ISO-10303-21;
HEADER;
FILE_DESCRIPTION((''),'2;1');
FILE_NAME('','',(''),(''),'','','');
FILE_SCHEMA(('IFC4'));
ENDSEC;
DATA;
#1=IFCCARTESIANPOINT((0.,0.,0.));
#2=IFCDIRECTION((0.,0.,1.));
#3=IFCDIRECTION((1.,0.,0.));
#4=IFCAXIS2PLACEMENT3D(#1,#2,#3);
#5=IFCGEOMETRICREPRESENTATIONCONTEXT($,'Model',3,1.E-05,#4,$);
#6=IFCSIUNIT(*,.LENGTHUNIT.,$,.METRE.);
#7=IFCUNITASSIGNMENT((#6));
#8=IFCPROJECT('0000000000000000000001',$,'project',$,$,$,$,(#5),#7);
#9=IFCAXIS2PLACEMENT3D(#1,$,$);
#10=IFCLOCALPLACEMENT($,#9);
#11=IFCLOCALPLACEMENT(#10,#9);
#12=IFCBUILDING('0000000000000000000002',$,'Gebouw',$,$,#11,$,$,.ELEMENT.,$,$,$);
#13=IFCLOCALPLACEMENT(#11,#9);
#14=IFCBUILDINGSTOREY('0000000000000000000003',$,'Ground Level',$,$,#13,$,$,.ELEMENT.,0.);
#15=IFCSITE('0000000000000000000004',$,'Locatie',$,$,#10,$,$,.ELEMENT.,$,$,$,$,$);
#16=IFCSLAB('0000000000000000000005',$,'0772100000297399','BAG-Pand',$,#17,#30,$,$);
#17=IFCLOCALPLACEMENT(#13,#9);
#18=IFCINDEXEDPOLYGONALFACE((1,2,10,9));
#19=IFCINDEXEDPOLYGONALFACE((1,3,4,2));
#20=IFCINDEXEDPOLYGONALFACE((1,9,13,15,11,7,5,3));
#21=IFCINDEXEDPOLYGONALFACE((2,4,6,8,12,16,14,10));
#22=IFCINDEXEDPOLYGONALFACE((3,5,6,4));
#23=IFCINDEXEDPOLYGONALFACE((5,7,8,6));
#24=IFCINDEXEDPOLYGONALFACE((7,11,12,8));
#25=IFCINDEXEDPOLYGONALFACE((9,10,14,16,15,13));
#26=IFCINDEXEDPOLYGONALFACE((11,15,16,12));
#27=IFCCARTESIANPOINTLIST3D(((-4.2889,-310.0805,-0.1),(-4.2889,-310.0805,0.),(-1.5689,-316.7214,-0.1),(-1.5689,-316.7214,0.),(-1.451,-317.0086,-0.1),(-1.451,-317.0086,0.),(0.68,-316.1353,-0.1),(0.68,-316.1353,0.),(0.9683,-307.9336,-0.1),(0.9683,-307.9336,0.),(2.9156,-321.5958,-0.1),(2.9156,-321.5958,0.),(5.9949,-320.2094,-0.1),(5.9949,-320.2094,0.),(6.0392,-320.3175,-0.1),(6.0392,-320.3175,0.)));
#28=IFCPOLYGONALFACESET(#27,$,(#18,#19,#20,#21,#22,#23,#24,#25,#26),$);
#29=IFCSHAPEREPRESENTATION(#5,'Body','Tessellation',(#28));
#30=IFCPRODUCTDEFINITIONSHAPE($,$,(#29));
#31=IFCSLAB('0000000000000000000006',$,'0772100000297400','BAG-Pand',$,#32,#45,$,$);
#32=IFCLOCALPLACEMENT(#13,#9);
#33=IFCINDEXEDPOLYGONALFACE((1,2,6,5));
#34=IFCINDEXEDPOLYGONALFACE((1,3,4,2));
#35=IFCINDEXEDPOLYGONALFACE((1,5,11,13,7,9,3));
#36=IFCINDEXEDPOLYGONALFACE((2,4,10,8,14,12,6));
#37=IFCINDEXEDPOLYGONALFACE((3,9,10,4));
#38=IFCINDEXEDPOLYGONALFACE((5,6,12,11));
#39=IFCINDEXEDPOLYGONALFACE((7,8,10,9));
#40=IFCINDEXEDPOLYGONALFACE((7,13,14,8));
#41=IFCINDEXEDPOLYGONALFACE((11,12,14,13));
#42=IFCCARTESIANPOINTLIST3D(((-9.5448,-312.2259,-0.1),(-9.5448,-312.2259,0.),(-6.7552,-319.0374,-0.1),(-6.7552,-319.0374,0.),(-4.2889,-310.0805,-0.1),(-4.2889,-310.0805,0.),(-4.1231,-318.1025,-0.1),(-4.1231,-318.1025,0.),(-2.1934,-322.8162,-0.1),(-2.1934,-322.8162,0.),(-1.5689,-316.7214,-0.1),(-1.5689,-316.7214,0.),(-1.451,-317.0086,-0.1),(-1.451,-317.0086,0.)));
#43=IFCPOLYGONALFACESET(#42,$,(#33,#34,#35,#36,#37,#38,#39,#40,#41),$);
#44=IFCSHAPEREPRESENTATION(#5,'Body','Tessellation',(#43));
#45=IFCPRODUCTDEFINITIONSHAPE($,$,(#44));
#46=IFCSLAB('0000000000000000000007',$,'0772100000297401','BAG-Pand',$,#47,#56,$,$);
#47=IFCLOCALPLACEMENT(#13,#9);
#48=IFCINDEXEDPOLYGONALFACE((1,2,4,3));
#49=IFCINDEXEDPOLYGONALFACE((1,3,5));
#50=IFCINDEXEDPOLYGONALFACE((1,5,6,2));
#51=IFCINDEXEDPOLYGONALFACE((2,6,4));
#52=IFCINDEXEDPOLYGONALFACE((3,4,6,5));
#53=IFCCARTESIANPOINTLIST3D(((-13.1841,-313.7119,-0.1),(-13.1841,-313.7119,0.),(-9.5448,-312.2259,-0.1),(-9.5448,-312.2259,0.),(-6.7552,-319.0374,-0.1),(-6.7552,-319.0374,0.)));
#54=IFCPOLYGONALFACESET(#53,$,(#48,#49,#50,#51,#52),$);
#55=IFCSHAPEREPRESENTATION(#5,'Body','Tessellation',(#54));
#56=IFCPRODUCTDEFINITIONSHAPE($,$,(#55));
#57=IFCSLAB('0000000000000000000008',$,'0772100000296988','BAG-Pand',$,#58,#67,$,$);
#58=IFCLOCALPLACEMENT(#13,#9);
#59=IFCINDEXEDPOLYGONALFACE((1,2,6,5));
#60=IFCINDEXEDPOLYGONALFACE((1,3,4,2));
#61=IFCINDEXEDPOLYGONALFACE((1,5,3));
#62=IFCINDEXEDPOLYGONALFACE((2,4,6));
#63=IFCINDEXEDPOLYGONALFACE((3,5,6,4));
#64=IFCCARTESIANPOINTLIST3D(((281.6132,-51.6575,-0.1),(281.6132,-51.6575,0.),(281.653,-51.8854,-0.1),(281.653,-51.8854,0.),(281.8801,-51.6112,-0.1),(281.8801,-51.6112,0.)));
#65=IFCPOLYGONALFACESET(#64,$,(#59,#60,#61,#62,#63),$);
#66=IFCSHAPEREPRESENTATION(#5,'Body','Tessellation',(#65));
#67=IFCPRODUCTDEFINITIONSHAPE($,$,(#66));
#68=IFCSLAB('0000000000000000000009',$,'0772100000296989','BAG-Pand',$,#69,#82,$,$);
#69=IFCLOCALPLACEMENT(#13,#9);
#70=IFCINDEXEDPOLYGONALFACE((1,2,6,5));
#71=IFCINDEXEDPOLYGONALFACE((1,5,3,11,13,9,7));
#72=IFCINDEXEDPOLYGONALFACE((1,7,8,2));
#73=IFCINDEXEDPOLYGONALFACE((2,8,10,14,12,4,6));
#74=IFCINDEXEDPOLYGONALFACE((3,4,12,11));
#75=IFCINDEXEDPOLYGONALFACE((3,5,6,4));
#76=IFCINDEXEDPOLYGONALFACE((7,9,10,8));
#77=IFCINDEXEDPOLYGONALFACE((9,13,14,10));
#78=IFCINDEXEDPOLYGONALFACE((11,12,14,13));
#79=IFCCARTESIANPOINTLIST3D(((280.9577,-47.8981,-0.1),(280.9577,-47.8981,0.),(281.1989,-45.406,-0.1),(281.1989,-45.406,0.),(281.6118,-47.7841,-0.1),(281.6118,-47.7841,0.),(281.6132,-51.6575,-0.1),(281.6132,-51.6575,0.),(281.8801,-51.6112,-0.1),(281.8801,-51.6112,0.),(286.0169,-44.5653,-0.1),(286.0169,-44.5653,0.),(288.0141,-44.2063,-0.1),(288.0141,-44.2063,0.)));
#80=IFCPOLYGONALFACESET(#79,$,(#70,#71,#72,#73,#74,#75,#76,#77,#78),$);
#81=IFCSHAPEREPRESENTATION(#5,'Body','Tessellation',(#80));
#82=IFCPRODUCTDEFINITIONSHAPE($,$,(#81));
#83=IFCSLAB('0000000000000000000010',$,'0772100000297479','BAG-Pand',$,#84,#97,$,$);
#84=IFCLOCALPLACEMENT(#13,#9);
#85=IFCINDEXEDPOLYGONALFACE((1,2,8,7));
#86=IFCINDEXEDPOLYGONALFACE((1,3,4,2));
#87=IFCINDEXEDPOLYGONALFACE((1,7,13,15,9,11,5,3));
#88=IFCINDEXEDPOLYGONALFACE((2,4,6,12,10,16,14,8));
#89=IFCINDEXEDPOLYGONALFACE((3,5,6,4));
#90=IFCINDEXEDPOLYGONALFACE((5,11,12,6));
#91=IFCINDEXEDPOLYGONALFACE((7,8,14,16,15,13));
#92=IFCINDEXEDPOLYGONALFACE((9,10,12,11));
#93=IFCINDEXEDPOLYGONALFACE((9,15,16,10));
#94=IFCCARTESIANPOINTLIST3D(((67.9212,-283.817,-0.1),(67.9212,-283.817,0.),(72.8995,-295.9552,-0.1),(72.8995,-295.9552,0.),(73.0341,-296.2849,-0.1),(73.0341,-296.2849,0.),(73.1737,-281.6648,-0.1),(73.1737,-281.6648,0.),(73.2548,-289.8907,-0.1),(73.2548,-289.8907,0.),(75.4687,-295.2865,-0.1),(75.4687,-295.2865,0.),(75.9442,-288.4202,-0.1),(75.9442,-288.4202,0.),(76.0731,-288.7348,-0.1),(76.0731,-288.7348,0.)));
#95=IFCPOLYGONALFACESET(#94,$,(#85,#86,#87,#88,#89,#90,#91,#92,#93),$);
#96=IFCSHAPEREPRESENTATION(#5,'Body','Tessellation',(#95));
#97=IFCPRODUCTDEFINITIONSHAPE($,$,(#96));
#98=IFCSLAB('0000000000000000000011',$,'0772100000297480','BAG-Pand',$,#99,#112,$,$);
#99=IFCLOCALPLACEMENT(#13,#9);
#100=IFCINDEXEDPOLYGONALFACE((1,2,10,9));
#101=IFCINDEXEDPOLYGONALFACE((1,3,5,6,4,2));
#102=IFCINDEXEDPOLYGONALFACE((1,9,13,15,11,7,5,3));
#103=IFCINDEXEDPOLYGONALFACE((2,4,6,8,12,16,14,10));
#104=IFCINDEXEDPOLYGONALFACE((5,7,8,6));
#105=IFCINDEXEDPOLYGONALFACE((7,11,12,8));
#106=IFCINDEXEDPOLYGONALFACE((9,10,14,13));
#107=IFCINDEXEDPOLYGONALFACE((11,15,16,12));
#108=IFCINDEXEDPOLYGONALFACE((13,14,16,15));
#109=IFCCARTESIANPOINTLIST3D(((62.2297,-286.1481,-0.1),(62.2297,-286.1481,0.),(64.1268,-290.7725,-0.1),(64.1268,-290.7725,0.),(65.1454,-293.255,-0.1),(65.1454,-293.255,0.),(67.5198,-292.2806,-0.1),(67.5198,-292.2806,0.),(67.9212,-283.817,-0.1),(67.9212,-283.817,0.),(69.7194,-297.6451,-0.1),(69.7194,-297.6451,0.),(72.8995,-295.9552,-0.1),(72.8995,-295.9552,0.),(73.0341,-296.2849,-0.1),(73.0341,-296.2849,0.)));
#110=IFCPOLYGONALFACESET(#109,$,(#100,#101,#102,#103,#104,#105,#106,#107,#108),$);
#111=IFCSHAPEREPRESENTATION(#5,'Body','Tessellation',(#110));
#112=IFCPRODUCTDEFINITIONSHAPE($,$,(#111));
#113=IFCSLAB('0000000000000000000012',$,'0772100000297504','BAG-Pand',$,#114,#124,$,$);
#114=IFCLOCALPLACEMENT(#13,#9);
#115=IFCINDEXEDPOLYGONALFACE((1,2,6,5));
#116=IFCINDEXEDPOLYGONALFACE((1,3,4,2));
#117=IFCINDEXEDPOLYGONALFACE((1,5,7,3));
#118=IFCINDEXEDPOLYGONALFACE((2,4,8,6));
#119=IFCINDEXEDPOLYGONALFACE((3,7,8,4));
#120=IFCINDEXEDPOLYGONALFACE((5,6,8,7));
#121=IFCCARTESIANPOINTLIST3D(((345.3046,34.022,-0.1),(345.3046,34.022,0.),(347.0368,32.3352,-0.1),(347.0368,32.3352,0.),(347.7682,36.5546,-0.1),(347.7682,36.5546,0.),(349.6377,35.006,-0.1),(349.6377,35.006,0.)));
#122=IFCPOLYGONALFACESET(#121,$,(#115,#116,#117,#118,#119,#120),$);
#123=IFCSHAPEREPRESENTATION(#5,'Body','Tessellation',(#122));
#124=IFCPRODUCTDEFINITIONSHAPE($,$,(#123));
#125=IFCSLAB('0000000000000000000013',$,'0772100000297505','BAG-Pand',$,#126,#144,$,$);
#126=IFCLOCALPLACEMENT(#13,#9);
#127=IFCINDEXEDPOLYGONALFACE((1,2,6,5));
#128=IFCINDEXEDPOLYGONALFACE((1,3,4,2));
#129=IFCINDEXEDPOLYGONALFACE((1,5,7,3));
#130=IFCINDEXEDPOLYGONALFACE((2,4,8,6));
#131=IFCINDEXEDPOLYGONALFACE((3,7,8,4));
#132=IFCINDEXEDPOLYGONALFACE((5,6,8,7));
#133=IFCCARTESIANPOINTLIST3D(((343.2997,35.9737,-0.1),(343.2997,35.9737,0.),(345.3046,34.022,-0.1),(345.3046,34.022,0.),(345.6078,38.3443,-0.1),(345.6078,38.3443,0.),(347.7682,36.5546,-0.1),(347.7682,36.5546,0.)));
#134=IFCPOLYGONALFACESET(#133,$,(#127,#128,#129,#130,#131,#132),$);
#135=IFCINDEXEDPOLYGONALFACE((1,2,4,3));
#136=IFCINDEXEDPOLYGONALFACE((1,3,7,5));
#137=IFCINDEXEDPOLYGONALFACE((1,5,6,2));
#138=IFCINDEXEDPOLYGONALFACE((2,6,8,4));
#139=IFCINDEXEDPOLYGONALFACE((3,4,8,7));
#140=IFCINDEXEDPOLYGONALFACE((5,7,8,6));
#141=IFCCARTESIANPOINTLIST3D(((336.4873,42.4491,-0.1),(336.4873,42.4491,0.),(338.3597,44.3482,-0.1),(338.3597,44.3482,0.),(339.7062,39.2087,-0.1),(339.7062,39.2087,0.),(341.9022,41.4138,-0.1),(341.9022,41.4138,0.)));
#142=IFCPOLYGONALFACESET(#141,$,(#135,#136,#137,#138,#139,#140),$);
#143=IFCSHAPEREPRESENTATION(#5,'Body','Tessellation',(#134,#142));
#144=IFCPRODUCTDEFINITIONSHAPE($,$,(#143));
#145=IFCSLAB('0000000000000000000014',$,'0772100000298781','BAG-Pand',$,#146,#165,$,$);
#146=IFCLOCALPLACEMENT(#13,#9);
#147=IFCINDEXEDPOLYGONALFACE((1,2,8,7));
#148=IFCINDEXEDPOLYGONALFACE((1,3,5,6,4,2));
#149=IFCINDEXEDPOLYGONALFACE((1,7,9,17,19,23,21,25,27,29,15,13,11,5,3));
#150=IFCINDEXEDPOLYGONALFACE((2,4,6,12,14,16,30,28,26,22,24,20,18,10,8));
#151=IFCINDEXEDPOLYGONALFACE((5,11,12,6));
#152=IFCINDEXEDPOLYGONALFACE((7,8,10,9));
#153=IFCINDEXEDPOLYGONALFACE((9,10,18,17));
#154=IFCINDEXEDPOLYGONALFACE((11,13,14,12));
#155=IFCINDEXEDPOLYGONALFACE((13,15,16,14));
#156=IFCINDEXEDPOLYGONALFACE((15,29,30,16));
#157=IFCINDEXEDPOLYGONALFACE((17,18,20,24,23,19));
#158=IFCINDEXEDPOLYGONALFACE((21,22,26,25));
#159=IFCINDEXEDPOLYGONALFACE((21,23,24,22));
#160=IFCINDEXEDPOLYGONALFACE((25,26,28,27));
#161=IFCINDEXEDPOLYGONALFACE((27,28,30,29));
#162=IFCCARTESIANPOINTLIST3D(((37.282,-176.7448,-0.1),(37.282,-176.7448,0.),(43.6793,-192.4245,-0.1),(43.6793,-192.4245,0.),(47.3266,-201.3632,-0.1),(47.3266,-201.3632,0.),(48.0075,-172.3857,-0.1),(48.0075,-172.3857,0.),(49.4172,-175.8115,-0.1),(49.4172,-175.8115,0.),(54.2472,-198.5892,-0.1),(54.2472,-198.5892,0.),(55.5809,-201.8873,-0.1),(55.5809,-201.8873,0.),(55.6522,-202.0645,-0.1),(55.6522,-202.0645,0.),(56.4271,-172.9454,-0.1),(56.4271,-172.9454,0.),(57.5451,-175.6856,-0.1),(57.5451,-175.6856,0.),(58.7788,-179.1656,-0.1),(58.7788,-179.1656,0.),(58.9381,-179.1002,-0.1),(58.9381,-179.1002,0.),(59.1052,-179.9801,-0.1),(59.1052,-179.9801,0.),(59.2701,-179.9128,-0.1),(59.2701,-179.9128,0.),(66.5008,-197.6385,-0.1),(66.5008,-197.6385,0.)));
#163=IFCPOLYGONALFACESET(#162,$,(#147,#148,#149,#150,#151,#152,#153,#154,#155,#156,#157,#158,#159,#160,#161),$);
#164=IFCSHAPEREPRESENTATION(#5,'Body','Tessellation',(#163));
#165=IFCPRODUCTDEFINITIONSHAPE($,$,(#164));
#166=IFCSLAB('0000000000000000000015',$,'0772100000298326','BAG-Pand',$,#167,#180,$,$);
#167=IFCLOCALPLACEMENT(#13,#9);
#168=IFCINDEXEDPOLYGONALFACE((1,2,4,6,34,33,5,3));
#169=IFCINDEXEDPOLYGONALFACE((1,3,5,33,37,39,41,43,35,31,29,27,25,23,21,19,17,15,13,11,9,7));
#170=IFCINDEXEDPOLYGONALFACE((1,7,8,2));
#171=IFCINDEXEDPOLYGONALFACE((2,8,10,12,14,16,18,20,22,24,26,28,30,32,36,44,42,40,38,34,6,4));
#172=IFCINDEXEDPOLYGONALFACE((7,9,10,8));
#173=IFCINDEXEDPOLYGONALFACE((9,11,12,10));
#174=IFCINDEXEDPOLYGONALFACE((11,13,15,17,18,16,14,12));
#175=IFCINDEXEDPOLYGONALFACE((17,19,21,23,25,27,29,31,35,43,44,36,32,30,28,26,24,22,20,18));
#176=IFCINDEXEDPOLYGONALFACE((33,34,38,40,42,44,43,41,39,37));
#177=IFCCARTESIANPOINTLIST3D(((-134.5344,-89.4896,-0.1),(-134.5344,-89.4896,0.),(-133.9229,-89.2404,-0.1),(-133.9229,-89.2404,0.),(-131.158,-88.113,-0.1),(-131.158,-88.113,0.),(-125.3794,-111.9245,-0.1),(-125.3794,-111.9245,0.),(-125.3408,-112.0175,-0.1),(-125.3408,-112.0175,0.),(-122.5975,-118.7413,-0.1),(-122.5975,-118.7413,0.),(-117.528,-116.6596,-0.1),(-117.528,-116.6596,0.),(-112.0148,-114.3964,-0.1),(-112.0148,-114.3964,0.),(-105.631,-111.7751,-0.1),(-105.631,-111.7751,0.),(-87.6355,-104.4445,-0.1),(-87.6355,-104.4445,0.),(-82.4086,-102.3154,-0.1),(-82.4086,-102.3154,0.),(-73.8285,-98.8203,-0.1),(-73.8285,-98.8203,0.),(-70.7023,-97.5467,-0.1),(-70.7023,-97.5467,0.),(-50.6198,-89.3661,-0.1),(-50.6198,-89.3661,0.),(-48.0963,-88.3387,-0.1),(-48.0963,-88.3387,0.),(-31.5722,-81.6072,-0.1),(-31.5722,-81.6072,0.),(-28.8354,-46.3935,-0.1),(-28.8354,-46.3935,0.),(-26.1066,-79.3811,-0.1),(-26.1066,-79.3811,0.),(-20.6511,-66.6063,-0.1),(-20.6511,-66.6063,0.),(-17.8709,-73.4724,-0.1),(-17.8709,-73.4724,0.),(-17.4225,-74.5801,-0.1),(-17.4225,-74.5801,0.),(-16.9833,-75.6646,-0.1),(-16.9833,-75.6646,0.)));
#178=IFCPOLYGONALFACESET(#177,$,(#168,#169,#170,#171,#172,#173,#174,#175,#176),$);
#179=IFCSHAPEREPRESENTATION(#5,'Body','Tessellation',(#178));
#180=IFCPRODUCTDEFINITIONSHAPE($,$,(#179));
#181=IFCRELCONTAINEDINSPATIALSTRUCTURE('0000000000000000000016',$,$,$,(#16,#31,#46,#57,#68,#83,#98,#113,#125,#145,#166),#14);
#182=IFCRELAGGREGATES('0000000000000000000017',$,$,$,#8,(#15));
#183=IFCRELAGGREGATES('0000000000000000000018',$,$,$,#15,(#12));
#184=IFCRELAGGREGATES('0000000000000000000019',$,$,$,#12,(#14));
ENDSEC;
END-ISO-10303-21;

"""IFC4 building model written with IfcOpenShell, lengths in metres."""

from ifc_helpers import new_model, si_unit, frame, origin, origin_with_axes, place, context, project, spatial, polyline, outline, extrude, element, save


model = new_model("IFC4")

# Units and contexts
model_context = context("Model", 3, precision=1e-05, world=origin_with_axes())
ifc_project = project(units=[si_unit("LENGTHUNIT", "METRE")], contexts=[model_context])

# Site, building, storey
site_placement = place(None, origin())
site = spatial("IfcSite", under=ifc_project, at=site_placement, Name="Locatie", CompositionType="ELEMENT")
building_placement = place(site_placement, origin())
building = spatial("IfcBuilding", under=site, at=building_placement, Name="Gebouw", CompositionType="ELEMENT")
storey_placement = place(building_placement, origin())
storey = spatial("IfcBuildingStorey", under=building, at=storey_placement, Name="Ground Level", CompositionType="ELEMENT", Elevation=0.0)

# Slabs
slab_1_placement = place(storey_placement, origin())
element("IfcSlab", 1, at=slab_1_placement, inside=storey, Name="0772100000297399", Description="BAG-Pand", context=model_context, shape_type="SweptSolid", body=[
    extrude(outline(polyline([(0.9683, -307.9336), (5.9949, -320.2094), (6.0392, -320.3175), (2.9156, -321.5958), (0.68, -316.1353), (-1.451, -317.0086), (-1.5689, -316.7214), (-4.2889, -310.0805), (0.9683, -307.9336)])), frame((0.0, 0.0, -0.1), z_axis=(0.0, 0.0, 1.0), x_axis=(1.0, 0.0, 0.0)), (0.0, 0.0, 1.0), 0.1),
])
slab_2_placement = place(storey_placement, origin())
element("IfcSlab", 2, at=slab_2_placement, inside=storey, Name="0772100000297400", Description="BAG-Pand", context=model_context, shape_type="SweptSolid", body=[
    extrude(outline(polyline([(-9.5448, -312.2259), (-4.2889, -310.0805), (-1.5689, -316.7214), (-1.451, -317.0086), (-4.1231, -318.1025), (-2.1934, -322.8162), (-6.7552, -319.0374), (-9.5448, -312.2259)])), frame((0.0, 0.0, -0.1), z_axis=(0.0, 0.0, 1.0), x_axis=(1.0, 0.0, 0.0)), (0.0, 0.0, 1.0), 0.1),
])
slab_3_placement = place(storey_placement, origin())
element("IfcSlab", 3, at=slab_3_placement, inside=storey, Name="0772100000297401", Description="BAG-Pand", context=model_context, shape_type="SweptSolid", body=[
    extrude(outline(polyline([(-9.5448, -312.2259), (-6.7552, -319.0374), (-13.1841, -313.7119), (-9.5448, -312.2259)])), frame((0.0, 0.0, -0.1), z_axis=(0.0, 0.0, 1.0), x_axis=(1.0, 0.0, 0.0)), (0.0, 0.0, 1.0), 0.1),
])
slab_4_placement = place(storey_placement, origin())
element("IfcSlab", 4, at=slab_4_placement, inside=storey, Name="0772100000296988", Description="BAG-Pand", context=model_context, shape_type="SweptSolid", body=[
    extrude(outline(polyline([(281.6132, -51.6575), (281.8801, -51.6112), (281.653, -51.8854), (281.6132, -51.6575)])), frame((0.0, 0.0, -0.1), z_axis=(0.0, 0.0, 1.0), x_axis=(1.0, 0.0, 0.0)), (0.0, 0.0, 1.0), 0.1),
])
slab_5_placement = place(storey_placement, origin())
element("IfcSlab", 5, at=slab_5_placement, inside=storey, Name="0772100000296989", Description="BAG-Pand", context=model_context, shape_type="SweptSolid", body=[
    extrude(outline(polyline([(281.6132, -51.6575), (280.9577, -47.8981), (281.6118, -47.7841), (281.1989, -45.406), (286.0169, -44.5653), (288.0141, -44.2063), (281.8801, -51.6112), (281.6132, -51.6575)])), frame((0.0, 0.0, -0.1), z_axis=(0.0, 0.0, 1.0), x_axis=(1.0, 0.0, 0.0)), (0.0, 0.0, 1.0), 0.1),
])
slab_6_placement = place(storey_placement, origin())
element("IfcSlab", 6, at=slab_6_placement, inside=storey, Name="0772100000297479", Description="BAG-Pand", context=model_context, shape_type="SweptSolid", body=[
    extrude(outline(polyline([(73.0341, -296.2849), (72.8995, -295.9552), (67.9212, -283.817), (73.1737, -281.6648), (75.9442, -288.4202), (76.0731, -288.7348), (73.2548, -289.8907), (75.4687, -295.2865), (73.0341, -296.2849)])), frame((0.0, 0.0, -0.1), z_axis=(0.0, 0.0, 1.0), x_axis=(1.0, 0.0, 0.0)), (0.0, 0.0, 1.0), 0.1),
])
slab_7_placement = place(storey_placement, origin())
element("IfcSlab", 7, at=slab_7_placement, inside=storey, Name="0772100000297480", Description="BAG-Pand", context=model_context, shape_type="SweptSolid", body=[
    extrude(outline(polyline([(67.9212, -283.817), (72.8995, -295.9552), (73.0341, -296.2849), (69.7194, -297.6451), (67.5198, -292.2806), (65.1454, -293.255), (64.1268, -290.7725), (62.2297, -286.1481), (67.9212, -283.817)])), frame((0.0, 0.0, -0.1), z_axis=(0.0, 0.0, 1.0), x_axis=(1.0, 0.0, 0.0)), (0.0, 0.0, 1.0), 0.1),
])
slab_8_placement = place(storey_placement, origin())
element("IfcSlab", 8, at=slab_8_placement, inside=storey, Name="0772100000297504", Description="BAG-Pand", context=model_context, shape_type="SweptSolid", body=[
    extrude(outline(polyline([(347.0368, 32.3352), (345.3046, 34.022), (347.7682, 36.5546), (349.6377, 35.006), (347.0368, 32.3352)])), frame((0.0, 0.0, -0.1), z_axis=(0.0, 0.0, 1.0), x_axis=(1.0, 0.0, 0.0)), (0.0, 0.0, 1.0), 0.1),
])
slab_9_placement = place(storey_placement, origin())
element("IfcSlab", 9, at=slab_9_placement, inside=storey, Name="0772100000297505", Description="BAG-Pand", context=model_context, shape_type="SweptSolid", body=[
    extrude(outline(polyline([(345.3046, 34.022), (343.2997, 35.9737), (345.6078, 38.3443), (347.7682, 36.5546), (345.3046, 34.022)])), frame((0.0, 0.0, -0.1), z_axis=(0.0, 0.0, 1.0), x_axis=(1.0, 0.0, 0.0)), (0.0, 0.0, 1.0), 0.1),
    extrude(outline(polyline([(339.7062, 39.2087), (336.4873, 42.4491), (338.3597, 44.3482), (341.9022, 41.4138), (339.7062, 39.2087)])), frame((0.0, 0.0, -0.1), z_axis=(0.0, 0.0, 1.0), x_axis=(1.0, 0.0, 0.0)), (0.0, 0.0, 1.0), 0.1),
])
slab_10_placement = place(storey_placement, origin())
element("IfcSlab", 10, at=slab_10_placement, inside=storey, Name="0772100000298781", Description="BAG-Pand", context=model_context, shape_type="SweptSolid", body=[
    extrude(outline(polyline([(54.2472, -198.5892), (47.3266, -201.3632), (43.6793, -192.4245), (37.282, -176.7448), (48.0075, -172.3857), (49.4172, -175.8115), (56.4271, -172.9454), (57.5451, -175.6856), (58.9381, -179.1002), (58.7788, -179.1656), (59.1052, -179.9801), (59.2701, -179.9128), (66.5008, -197.6385), (55.6522, -202.0645), (55.5809, -201.8873), (54.2472, -198.5892)])), frame((0.0, 0.0, -0.1), z_axis=(0.0, 0.0, 1.0), x_axis=(1.0, 0.0, 0.0)), (0.0, 0.0, 1.0), 0.1),
])
slab_11_placement = place(storey_placement, origin())
element("IfcSlab", 11, at=slab_11_placement, inside=storey, Name="0772100000298326", Description="BAG-Pand", context=model_context, shape_type="SweptSolid", body=[
    extrude(outline(polyline([(-125.3408, -112.0175), (-125.3794, -111.9245), (-134.5344, -89.4896), (-133.9229, -89.2404), (-131.158, -88.113), (-28.8354, -46.3935), (-20.6511, -66.6063), (-17.8709, -73.4724), (-17.4225, -74.5801), (-16.9833, -75.6646), (-26.1066, -79.3811), (-31.5722, -81.6072), (-48.0963, -88.3387), (-50.6198, -89.3661), (-70.7023, -97.5467), (-73.8285, -98.8203), (-82.4086, -102.3154), (-87.6355, -104.4445), (-105.631, -111.7751), (-112.0148, -114.3964), (-117.528, -116.6596), (-122.5975, -118.7413), (-125.3408, -112.0175)])), frame((0.0, 0.0, -0.1), z_axis=(0.0, 0.0, 1.0), x_axis=(1.0, 0.0, 0.0)), (0.0, 0.0, 1.0), 0.1),
])

save(model, "model.ifc")
